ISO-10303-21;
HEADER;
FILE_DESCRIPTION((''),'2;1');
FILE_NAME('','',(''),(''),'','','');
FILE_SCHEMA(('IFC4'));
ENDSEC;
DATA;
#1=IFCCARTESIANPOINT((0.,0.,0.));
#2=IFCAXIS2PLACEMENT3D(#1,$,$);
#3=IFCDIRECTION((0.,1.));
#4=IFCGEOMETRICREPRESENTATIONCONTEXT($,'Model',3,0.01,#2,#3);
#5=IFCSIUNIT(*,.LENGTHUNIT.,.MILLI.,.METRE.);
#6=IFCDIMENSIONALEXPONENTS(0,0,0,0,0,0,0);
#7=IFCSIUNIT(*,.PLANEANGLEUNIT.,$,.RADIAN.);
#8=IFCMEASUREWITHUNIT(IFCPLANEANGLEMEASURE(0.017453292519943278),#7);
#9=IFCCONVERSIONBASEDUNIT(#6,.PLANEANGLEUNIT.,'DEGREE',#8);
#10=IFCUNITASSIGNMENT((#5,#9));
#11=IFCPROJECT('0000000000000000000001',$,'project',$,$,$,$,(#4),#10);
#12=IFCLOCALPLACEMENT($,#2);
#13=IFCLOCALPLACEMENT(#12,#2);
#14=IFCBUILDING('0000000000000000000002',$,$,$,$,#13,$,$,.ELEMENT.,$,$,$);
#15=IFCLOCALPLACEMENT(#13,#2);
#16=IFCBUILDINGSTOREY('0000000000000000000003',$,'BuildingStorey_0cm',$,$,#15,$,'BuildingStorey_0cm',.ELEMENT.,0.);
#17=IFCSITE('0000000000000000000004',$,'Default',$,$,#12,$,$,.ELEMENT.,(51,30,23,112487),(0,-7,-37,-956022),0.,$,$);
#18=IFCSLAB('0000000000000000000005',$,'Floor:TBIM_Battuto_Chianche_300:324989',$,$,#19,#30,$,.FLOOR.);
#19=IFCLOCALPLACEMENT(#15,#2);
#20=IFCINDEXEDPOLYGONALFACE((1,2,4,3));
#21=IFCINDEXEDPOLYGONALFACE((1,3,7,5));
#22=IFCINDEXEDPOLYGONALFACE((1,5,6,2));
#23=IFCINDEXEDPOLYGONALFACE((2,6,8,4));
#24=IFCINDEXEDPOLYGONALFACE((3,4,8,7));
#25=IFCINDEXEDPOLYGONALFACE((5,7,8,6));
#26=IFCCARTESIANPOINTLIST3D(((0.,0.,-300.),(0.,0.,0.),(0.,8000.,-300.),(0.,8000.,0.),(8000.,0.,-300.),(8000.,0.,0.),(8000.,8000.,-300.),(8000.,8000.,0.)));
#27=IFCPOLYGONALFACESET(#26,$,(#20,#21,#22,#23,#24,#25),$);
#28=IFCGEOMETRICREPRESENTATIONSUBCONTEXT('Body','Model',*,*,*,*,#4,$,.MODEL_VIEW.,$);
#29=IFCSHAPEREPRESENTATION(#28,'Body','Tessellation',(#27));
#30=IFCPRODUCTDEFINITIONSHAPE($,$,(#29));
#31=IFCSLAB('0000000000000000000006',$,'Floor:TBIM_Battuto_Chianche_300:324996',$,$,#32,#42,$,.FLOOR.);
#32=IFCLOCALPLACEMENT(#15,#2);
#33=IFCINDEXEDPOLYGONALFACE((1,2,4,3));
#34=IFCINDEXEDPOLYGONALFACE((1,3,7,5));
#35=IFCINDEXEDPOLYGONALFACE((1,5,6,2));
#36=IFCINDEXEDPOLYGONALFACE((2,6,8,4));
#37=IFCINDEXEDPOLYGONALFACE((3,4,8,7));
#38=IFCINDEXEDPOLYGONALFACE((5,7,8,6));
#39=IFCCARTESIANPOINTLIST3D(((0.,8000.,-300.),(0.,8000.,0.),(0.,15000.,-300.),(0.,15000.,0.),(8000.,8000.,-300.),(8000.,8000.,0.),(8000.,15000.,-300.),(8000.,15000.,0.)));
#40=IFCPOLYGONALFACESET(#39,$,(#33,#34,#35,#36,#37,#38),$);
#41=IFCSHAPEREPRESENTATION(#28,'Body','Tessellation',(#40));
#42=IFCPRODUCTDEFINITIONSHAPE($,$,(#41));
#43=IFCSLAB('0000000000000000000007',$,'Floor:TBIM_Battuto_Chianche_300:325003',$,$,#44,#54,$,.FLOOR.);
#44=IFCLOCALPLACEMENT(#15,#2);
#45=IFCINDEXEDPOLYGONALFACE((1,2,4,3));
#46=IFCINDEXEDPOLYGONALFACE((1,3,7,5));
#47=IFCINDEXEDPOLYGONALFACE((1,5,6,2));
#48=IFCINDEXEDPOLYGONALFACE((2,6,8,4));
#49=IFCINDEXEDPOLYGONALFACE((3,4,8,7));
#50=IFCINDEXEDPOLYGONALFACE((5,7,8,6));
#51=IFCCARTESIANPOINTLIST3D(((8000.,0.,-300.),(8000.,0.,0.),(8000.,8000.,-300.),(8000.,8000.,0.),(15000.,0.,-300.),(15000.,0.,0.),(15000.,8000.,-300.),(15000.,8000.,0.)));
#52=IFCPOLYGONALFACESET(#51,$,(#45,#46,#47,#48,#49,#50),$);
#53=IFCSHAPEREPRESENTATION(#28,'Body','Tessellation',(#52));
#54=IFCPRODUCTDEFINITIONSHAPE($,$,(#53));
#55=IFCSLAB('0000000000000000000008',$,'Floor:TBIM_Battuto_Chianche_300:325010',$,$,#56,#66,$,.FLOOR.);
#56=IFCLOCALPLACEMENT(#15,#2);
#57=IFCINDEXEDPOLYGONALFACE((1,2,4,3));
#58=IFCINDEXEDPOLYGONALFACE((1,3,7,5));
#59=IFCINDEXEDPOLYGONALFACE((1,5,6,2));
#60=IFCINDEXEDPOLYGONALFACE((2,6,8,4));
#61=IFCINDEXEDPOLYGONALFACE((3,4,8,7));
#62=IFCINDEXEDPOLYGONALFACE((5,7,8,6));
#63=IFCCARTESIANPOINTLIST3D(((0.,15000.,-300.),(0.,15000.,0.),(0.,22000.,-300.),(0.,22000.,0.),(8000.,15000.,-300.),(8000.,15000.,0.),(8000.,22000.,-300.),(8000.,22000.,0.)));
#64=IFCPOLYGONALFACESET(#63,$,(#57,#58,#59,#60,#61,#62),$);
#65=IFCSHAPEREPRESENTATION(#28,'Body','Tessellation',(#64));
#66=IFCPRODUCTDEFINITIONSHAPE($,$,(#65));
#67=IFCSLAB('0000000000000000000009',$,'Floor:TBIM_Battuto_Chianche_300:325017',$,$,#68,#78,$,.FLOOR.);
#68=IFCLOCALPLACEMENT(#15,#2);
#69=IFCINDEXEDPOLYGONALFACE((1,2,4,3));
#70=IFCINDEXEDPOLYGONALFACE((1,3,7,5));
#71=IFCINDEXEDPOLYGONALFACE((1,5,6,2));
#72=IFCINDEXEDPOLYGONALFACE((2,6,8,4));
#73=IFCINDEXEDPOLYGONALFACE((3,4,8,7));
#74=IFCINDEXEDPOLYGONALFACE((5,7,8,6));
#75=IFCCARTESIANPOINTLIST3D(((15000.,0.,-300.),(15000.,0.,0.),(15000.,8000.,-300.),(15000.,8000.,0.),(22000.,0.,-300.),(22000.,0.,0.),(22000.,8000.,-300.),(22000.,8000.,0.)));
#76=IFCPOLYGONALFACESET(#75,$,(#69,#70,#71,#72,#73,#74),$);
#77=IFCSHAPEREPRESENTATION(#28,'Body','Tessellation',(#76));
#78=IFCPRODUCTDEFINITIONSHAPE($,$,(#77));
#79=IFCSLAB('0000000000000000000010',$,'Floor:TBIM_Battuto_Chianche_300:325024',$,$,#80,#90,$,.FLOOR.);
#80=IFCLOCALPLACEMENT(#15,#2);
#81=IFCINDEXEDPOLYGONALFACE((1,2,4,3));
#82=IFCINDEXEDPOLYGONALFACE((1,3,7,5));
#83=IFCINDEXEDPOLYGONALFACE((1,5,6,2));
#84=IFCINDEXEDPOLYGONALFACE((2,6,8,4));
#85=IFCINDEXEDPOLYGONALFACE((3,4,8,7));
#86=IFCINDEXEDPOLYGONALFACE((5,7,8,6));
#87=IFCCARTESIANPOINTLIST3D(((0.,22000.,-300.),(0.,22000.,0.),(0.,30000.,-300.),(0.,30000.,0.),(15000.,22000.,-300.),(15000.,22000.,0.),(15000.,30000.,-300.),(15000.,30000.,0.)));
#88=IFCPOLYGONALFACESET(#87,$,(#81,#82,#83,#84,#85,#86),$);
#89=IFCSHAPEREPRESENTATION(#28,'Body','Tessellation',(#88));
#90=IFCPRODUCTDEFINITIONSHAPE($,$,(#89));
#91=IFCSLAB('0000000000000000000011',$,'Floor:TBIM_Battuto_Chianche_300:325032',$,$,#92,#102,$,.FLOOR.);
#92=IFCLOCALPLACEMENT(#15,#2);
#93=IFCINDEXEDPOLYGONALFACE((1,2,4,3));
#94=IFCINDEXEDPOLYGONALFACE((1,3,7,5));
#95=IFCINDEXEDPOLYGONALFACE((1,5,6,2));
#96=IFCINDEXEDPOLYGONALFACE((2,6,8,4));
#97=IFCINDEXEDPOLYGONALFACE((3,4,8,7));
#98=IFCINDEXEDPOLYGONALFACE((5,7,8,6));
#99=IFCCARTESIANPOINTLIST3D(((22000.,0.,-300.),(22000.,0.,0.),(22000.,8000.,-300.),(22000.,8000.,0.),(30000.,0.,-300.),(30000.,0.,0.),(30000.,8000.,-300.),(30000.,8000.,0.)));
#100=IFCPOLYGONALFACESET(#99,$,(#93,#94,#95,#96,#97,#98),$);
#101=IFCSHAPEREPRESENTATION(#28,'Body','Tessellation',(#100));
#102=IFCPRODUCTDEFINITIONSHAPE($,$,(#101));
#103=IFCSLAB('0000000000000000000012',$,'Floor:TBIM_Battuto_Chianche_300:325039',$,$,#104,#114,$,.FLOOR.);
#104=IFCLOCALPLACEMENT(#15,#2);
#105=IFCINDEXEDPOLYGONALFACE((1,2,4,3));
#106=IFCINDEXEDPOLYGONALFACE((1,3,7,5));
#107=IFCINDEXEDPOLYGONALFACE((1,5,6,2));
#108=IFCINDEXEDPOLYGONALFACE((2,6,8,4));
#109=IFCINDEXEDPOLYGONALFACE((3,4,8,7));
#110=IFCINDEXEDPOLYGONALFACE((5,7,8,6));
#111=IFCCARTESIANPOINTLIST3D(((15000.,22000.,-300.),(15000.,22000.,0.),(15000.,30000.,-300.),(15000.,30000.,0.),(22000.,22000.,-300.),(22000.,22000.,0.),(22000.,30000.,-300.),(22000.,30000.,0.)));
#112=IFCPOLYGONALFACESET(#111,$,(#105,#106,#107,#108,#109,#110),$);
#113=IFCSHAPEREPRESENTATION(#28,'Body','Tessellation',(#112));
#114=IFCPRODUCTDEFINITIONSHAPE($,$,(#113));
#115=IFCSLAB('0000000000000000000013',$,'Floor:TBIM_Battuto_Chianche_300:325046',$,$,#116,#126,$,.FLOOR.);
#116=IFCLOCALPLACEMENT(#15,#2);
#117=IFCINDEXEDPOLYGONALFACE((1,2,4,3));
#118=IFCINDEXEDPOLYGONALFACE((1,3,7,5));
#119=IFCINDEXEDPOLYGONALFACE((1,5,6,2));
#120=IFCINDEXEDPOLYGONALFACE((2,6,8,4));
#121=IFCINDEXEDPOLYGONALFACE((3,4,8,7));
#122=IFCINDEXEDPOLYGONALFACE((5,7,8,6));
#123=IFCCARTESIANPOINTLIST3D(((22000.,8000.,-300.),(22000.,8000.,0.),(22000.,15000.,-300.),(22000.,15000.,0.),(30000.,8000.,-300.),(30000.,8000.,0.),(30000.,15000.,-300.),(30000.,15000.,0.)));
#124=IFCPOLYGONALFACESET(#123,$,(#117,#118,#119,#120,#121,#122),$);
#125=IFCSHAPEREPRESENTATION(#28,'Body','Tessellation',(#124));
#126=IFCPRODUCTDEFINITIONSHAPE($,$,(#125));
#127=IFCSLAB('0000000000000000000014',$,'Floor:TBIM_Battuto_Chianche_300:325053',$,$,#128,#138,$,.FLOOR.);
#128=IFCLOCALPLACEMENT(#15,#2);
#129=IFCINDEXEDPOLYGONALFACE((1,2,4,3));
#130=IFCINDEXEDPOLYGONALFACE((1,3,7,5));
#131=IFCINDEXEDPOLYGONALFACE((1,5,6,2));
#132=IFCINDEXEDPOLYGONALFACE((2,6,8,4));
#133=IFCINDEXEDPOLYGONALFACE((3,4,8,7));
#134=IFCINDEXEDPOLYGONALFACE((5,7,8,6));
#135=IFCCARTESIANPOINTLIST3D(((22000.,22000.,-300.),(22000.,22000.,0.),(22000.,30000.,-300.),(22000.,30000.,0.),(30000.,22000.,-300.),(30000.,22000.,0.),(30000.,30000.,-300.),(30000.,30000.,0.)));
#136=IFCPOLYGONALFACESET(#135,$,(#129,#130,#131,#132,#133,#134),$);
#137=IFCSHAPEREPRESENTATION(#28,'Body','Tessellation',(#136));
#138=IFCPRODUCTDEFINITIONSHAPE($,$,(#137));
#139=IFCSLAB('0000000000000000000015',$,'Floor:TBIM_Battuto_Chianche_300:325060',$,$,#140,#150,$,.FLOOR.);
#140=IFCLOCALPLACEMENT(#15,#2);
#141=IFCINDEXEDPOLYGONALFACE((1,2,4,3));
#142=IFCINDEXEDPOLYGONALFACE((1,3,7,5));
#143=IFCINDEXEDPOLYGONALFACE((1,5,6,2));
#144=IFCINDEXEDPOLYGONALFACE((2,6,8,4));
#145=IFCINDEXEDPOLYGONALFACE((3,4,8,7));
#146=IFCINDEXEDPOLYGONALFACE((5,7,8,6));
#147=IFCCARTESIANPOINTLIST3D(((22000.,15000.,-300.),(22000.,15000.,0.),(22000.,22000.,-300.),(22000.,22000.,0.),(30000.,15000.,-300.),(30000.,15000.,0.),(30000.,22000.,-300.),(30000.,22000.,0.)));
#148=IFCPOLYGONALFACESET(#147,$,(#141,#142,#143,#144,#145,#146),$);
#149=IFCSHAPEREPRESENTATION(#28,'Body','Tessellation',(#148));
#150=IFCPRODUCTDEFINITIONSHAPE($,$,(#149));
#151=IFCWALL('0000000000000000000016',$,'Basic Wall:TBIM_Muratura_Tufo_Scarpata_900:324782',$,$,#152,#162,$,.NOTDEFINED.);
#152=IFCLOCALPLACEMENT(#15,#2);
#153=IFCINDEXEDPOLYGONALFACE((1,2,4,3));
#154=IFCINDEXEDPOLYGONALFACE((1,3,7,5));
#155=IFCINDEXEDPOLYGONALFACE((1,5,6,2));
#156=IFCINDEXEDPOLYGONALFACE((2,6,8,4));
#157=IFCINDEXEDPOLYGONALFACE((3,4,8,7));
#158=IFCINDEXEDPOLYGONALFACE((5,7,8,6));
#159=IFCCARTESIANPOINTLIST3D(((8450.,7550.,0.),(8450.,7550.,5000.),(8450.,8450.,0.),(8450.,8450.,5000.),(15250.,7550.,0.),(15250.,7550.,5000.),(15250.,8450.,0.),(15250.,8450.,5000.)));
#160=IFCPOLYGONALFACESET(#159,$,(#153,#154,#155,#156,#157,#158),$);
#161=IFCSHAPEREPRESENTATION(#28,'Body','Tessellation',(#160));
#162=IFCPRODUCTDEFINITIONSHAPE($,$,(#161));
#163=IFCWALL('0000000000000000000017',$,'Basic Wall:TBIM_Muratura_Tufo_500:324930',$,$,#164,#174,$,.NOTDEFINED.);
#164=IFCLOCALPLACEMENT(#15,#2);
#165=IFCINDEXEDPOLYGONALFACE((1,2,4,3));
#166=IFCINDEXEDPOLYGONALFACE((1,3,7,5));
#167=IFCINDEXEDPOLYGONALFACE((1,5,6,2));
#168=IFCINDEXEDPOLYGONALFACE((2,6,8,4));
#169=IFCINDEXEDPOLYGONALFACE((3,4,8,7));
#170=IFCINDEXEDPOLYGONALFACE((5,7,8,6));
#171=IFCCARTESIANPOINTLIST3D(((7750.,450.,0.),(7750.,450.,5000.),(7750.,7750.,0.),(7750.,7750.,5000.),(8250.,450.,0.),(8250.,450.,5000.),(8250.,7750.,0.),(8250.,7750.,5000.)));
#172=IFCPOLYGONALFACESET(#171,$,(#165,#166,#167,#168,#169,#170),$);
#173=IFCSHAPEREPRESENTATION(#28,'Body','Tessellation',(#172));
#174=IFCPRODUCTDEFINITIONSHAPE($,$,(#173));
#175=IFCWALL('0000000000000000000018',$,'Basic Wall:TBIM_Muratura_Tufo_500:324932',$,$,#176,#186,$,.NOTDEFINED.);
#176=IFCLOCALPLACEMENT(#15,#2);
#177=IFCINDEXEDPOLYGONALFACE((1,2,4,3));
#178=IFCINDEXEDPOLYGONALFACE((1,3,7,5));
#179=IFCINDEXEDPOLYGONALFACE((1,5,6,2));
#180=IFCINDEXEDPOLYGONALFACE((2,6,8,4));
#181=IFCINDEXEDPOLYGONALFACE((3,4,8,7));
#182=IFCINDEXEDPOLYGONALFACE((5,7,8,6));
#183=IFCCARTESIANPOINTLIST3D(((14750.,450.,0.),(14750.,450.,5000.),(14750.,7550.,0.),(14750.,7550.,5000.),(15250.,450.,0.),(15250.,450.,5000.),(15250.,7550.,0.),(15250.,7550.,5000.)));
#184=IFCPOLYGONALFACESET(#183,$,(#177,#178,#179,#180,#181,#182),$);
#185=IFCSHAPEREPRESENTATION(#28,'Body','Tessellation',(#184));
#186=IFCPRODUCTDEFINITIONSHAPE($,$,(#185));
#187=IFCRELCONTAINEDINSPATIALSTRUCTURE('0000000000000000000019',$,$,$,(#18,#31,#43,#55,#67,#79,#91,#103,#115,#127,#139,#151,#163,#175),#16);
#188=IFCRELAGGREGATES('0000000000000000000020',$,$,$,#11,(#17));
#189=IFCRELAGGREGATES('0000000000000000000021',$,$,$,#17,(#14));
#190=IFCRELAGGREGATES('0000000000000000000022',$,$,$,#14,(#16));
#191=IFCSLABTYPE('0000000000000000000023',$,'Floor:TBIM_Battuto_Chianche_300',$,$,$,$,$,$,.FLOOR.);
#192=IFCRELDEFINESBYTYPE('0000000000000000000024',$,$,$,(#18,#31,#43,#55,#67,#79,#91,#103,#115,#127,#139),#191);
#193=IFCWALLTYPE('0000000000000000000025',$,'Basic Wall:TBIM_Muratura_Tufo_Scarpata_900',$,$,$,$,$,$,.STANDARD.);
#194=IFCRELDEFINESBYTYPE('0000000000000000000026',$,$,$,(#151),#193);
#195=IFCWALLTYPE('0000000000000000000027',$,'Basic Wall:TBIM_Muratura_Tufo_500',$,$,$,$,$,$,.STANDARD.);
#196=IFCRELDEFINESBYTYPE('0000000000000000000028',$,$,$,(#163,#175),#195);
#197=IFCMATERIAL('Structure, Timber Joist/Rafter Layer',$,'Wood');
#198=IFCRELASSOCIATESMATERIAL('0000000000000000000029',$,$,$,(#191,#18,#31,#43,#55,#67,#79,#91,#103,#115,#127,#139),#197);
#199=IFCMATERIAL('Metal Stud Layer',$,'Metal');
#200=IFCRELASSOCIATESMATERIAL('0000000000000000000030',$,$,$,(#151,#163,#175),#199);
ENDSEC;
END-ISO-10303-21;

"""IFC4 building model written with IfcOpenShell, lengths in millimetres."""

from ifc_helpers import new_model, entity, si_unit, converted_unit, direction, frame, origin, place, context, subcontext, project, spatial, indexed_curve, outline, extrude, material, type_object, element, save


model = new_model("IFC4")

# Units and contexts
model_context = context("Model", 3, precision=0.01, world=origin(), true_north=direction((0.0, 1.0)))
body_context = subcontext(model_context, "Body", "Model", "MODEL_VIEW")
ifc_project = project(units=[si_unit("LENGTHUNIT", "METRE", prefix="MILLI"), converted_unit("PLANEANGLEUNIT", "DEGREE", entity("IfcPlaneAngleMeasure", 0.017453292519943278), si_unit("PLANEANGLEUNIT", "RADIAN"), dimensions=[0, 0, 0, 0, 0, 0, 0])], contexts=[model_context])

# Site, building, storey
site_placement = place(None, origin())
site = spatial("IfcSite", under=ifc_project, at=site_placement, Name="Default", CompositionType="ELEMENT", RefLatitude=(51, 30, 23, 112487), RefLongitude=(0, -7, -37, -956022), RefElevation=0.0)
building_placement = place(site_placement, origin())
building = spatial("IfcBuilding", under=site, at=building_placement, CompositionType="ELEMENT")
storey_placement = place(building_placement, origin())
storey = spatial("IfcBuildingStorey", under=building, at=storey_placement, Name="BuildingStorey_0cm", LongName="BuildingStorey_0cm", CompositionType="ELEMENT", Elevation=0.0)

# Slabs
ifc_material_1 = material(Name="Structure, Timber Joist/Rafter Layer", Category="Wood")
slab_type = type_object("IfcSlabType", Name="Floor:TBIM_Battuto_Chianche_300", PredefinedType="FLOOR", material=ifc_material_1)
slab_1_placement = place(storey_placement, origin())
element("IfcSlab", 1, at=slab_1_placement, inside=storey, type_object=slab_type, material=ifc_material_1, Name="Floor:TBIM_Battuto_Chianche_300:324989", PredefinedType="FLOOR", context=body_context, shape_type="SweptSolid", body=[
    extrude(outline(indexed_curve([(-4000.0, -4000.0), (4000.0, -4000.0), (4000.0, 4000.0), (-4000.0, 4000.0), (-4000.0, -4000.0)], self_intersect=False)), frame((4000.0, 4000.0, 0.0), z_axis=(0.0, 0.0, -1.0), x_axis=(0.0, 1.0, 0.0)), (0.0, 0.0, 1.0), 300.0),
])
slab_2_placement = place(storey_placement, origin())
element("IfcSlab", 2, at=slab_2_placement, inside=storey, type_object=slab_type, material=ifc_material_1, Name="Floor:TBIM_Battuto_Chianche_300:324996", PredefinedType="FLOOR", context=body_context, shape_type="SweptSolid", body=[
    extrude(outline(indexed_curve([(-3500.0, -4000.0), (3500.0, -4000.0), (3500.0, 4000.0), (-3500.0, 4000.0), (-3500.0, -4000.0)], self_intersect=False)), frame((4000.0, 11500.0, 0.0), z_axis=(0.0, 0.0, -1.0), x_axis=(0.0, 1.0, 0.0)), (0.0, 0.0, 1.0), 300.0),
])
slab_3_placement = place(storey_placement, origin())
element("IfcSlab", 3, at=slab_3_placement, inside=storey, type_object=slab_type, material=ifc_material_1, Name="Floor:TBIM_Battuto_Chianche_300:325003", PredefinedType="FLOOR", context=body_context, shape_type="SweptSolid", body=[
    extrude(outline(indexed_curve([(-4000.0, -3500.0), (4000.0, -3500.0), (4000.0, 3500.0), (-4000.0, 3500.0), (-4000.0, -3500.0)], self_intersect=False)), frame((11500.0, 4000.0, 0.0), z_axis=(0.0, 0.0, -1.0), x_axis=(0.0, 1.0, 0.0)), (0.0, 0.0, 1.0), 300.0),
])
slab_4_placement = place(storey_placement, origin())
element("IfcSlab", 4, at=slab_4_placement, inside=storey, type_object=slab_type, material=ifc_material_1, Name="Floor:TBIM_Battuto_Chianche_300:325010", PredefinedType="FLOOR", context=body_context, shape_type="SweptSolid", body=[
    extrude(outline(indexed_curve([(-3500.0, -4000.0), (3500.0, -4000.0), (3500.0, 4000.0), (-3500.0, 4000.0), (-3500.0, -4000.0)], self_intersect=False)), frame((4000.0, 18500.0, 0.0), z_axis=(0.0, 0.0, -1.0), x_axis=(0.0, 1.0, 0.0)), (0.0, 0.0, 1.0), 300.0),
])
slab_5_placement = place(storey_placement, origin())
element("IfcSlab", 5, at=slab_5_placement, inside=storey, type_object=slab_type, material=ifc_material_1, Name="Floor:TBIM_Battuto_Chianche_300:325017", PredefinedType="FLOOR", context=body_context, shape_type="SweptSolid", body=[
    extrude(outline(indexed_curve([(-4000.0, -3500.0), (4000.0, -3500.0), (4000.0, 3500.0), (-4000.0, 3500.0), (-4000.0, -3500.0)], self_intersect=False)), frame((18500.0, 4000.0, 0.0), z_axis=(0.0, 0.0, -1.0), x_axis=(0.0, 1.0, 0.0)), (0.0, 0.0, 1.0), 300.0),
])
slab_6_placement = place(storey_placement, origin())
element("IfcSlab", 6, at=slab_6_placement, inside=storey, type_object=slab_type, material=ifc_material_1, Name="Floor:TBIM_Battuto_Chianche_300:325024", PredefinedType="FLOOR", context=body_context, shape_type="SweptSolid", body=[
    extrude(outline(indexed_curve([(-4000.0, -7500.0), (4000.0, -7500.0), (4000.0, 7500.0), (-4000.0, 7500.0), (-4000.0, -7500.0)], self_intersect=False)), frame((7500.0, 26000.0, 0.0), z_axis=(0.0, 0.0, -1.0), x_axis=(0.0, 1.0, 0.0)), (0.0, 0.0, 1.0), 300.0),
])
slab_7_placement = place(storey_placement, origin())
element("IfcSlab", 7, at=slab_7_placement, inside=storey, type_object=slab_type, material=ifc_material_1, Name="Floor:TBIM_Battuto_Chianche_300:325032", PredefinedType="FLOOR", context=body_context, shape_type="SweptSolid", body=[
    extrude(outline(indexed_curve([(-4000.0, -4000.0), (4000.0, -4000.0), (4000.0, 4000.0), (-4000.0, 4000.0), (-4000.0, -4000.0)], self_intersect=False)), frame((26000.0, 4000.0, 0.0), z_axis=(0.0, 0.0, -1.0), x_axis=(0.0, 1.0, 0.0)), (0.0, 0.0, 1.0), 300.0),
])
slab_8_placement = place(storey_placement, origin())
element("IfcSlab", 8, at=slab_8_placement, inside=storey, type_object=slab_type, material=ifc_material_1, Name="Floor:TBIM_Battuto_Chianche_300:325039", PredefinedType="FLOOR", context=body_context, shape_type="SweptSolid", body=[
    extrude(outline(indexed_curve([(-4000.0, -3500.0), (4000.0, -3500.0), (4000.0, 3500.0), (-4000.0, 3500.0), (-4000.0, -3500.0)], self_intersect=False)), frame((18500.0, 26000.0, 0.0), z_axis=(0.0, 0.0, -1.0), x_axis=(0.0, 1.0, 0.0)), (0.0, 0.0, 1.0), 300.0),
])
slab_9_placement = place(storey_placement, origin())
element("IfcSlab", 9, at=slab_9_placement, inside=storey, type_object=slab_type, material=ifc_material_1, Name="Floor:TBIM_Battuto_Chianche_300:325046", PredefinedType="FLOOR", context=body_context, shape_type="SweptSolid", body=[
    extrude(outline(indexed_curve([(-3500.0, -4000.0), (3500.0, -4000.0), (3500.0, 4000.0), (-3500.0, 4000.0), (-3500.0, -4000.0)], self_intersect=False)), frame((26000.0, 11500.0, 0.0), z_axis=(0.0, 0.0, -1.0), x_axis=(0.0, 1.0, 0.0)), (0.0, 0.0, 1.0), 300.0),
])
slab_10_placement = place(storey_placement, origin())
element("IfcSlab", 10, at=slab_10_placement, inside=storey, type_object=slab_type, material=ifc_material_1, Name="Floor:TBIM_Battuto_Chianche_300:325053", PredefinedType="FLOOR", context=body_context, shape_type="SweptSolid", body=[
    extrude(outline(indexed_curve([(-4000.0, -4000.0), (4000.0, -4000.0), (4000.0, 4000.0), (-4000.0, 4000.0), (-4000.0, -4000.0)], self_intersect=False)), frame((26000.0, 26000.0, 0.0), z_axis=(0.0, 0.0, -1.0), x_axis=(0.0, 1.0, 0.0)), (0.0, 0.0, 1.0), 300.0),
])
slab_11_placement = place(storey_placement, origin())
element("IfcSlab", 11, at=slab_11_placement, inside=storey, type_object=slab_type, material=ifc_material_1, Name="Floor:TBIM_Battuto_Chianche_300:325060", PredefinedType="FLOOR", context=body_context, shape_type="SweptSolid", body=[
    extrude(outline(indexed_curve([(-3500.0, -4000.0), (3500.0, -4000.0), (3500.0, 4000.0), (-3500.0, 4000.0), (-3500.0, -4000.0)], self_intersect=False)), frame((26000.0, 18500.0, 0.0), z_axis=(0.0, 0.0, -1.0), x_axis=(0.0, 1.0, 0.0)), (0.0, 0.0, 1.0), 300.0),
])

# Walls
ifc_material_2 = material(Name="Metal Stud Layer", Category="Metal")
wall_type_1 = type_object("IfcWallType", Name="Basic Wall:TBIM_Muratura_Tufo_Scarpata_900", PredefinedType="STANDARD")
wall_1_placement = place(storey_placement, frame((8450.0, 8000.0, 0.0)))
element("IfcWall", 12, at=wall_1_placement, inside=storey, type_object=wall_type_1, material=ifc_material_2, Name="Basic Wall:TBIM_Muratura_Tufo_Scarpata_900:324782", PredefinedType="NOTDEFINED", context=body_context, shape_type="SweptSolid", body=[
    extrude(outline(indexed_curve([(6800.0, 450.0), (0.0, 450.0), (0.0, -450.0), (6800.0, -450.0), (6800.0, 450.0)], self_intersect=False)), origin(), (0.0, 0.0, 1.0), 5000.0),
])
wall_type_2 = type_object("IfcWallType", Name="Basic Wall:TBIM_Muratura_Tufo_500", PredefinedType="STANDARD")
wall_2_placement = place(storey_placement, frame((8000.0, 450.0, 0.0), z_axis=(0.0, 0.0, 1.0), x_axis=(0.0, 1.0, 0.0)))
element("IfcWall", 13, at=wall_2_placement, inside=storey, type_object=wall_type_2, material=ifc_material_2, Name="Basic Wall:TBIM_Muratura_Tufo_500:324930", PredefinedType="NOTDEFINED", context=body_context, shape_type="SweptSolid", body=[
    extrude(outline(indexed_curve([(7300.0, 250.0), (0.0, 250.0), (0.0, -250.0), (7300.0, -250.0), (7300.0, 250.0)], self_intersect=False)), origin(), (0.0, 0.0, 1.0), 5000.0),
])
wall_3_placement = place(storey_placement, frame((15000.0, 450.0, 0.0), z_axis=(0.0, 0.0, 1.0), x_axis=(0.0, 1.0, 0.0)))
element("IfcWall", 14, at=wall_3_placement, inside=storey, type_object=wall_type_2, material=ifc_material_2, Name="Basic Wall:TBIM_Muratura_Tufo_500:324932", PredefinedType="NOTDEFINED", context=body_context, shape_type="SweptSolid", body=[
    extrude(outline(indexed_curve([(7100.0, 250.0), (0.0, 250.0), (0.0, -250.0), (7100.0, -250.0), (7100.0, 250.0)], self_intersect=False)), origin(), (0.0, 0.0, 1.0), 5000.0),
])

save(model, "model.ifc")
